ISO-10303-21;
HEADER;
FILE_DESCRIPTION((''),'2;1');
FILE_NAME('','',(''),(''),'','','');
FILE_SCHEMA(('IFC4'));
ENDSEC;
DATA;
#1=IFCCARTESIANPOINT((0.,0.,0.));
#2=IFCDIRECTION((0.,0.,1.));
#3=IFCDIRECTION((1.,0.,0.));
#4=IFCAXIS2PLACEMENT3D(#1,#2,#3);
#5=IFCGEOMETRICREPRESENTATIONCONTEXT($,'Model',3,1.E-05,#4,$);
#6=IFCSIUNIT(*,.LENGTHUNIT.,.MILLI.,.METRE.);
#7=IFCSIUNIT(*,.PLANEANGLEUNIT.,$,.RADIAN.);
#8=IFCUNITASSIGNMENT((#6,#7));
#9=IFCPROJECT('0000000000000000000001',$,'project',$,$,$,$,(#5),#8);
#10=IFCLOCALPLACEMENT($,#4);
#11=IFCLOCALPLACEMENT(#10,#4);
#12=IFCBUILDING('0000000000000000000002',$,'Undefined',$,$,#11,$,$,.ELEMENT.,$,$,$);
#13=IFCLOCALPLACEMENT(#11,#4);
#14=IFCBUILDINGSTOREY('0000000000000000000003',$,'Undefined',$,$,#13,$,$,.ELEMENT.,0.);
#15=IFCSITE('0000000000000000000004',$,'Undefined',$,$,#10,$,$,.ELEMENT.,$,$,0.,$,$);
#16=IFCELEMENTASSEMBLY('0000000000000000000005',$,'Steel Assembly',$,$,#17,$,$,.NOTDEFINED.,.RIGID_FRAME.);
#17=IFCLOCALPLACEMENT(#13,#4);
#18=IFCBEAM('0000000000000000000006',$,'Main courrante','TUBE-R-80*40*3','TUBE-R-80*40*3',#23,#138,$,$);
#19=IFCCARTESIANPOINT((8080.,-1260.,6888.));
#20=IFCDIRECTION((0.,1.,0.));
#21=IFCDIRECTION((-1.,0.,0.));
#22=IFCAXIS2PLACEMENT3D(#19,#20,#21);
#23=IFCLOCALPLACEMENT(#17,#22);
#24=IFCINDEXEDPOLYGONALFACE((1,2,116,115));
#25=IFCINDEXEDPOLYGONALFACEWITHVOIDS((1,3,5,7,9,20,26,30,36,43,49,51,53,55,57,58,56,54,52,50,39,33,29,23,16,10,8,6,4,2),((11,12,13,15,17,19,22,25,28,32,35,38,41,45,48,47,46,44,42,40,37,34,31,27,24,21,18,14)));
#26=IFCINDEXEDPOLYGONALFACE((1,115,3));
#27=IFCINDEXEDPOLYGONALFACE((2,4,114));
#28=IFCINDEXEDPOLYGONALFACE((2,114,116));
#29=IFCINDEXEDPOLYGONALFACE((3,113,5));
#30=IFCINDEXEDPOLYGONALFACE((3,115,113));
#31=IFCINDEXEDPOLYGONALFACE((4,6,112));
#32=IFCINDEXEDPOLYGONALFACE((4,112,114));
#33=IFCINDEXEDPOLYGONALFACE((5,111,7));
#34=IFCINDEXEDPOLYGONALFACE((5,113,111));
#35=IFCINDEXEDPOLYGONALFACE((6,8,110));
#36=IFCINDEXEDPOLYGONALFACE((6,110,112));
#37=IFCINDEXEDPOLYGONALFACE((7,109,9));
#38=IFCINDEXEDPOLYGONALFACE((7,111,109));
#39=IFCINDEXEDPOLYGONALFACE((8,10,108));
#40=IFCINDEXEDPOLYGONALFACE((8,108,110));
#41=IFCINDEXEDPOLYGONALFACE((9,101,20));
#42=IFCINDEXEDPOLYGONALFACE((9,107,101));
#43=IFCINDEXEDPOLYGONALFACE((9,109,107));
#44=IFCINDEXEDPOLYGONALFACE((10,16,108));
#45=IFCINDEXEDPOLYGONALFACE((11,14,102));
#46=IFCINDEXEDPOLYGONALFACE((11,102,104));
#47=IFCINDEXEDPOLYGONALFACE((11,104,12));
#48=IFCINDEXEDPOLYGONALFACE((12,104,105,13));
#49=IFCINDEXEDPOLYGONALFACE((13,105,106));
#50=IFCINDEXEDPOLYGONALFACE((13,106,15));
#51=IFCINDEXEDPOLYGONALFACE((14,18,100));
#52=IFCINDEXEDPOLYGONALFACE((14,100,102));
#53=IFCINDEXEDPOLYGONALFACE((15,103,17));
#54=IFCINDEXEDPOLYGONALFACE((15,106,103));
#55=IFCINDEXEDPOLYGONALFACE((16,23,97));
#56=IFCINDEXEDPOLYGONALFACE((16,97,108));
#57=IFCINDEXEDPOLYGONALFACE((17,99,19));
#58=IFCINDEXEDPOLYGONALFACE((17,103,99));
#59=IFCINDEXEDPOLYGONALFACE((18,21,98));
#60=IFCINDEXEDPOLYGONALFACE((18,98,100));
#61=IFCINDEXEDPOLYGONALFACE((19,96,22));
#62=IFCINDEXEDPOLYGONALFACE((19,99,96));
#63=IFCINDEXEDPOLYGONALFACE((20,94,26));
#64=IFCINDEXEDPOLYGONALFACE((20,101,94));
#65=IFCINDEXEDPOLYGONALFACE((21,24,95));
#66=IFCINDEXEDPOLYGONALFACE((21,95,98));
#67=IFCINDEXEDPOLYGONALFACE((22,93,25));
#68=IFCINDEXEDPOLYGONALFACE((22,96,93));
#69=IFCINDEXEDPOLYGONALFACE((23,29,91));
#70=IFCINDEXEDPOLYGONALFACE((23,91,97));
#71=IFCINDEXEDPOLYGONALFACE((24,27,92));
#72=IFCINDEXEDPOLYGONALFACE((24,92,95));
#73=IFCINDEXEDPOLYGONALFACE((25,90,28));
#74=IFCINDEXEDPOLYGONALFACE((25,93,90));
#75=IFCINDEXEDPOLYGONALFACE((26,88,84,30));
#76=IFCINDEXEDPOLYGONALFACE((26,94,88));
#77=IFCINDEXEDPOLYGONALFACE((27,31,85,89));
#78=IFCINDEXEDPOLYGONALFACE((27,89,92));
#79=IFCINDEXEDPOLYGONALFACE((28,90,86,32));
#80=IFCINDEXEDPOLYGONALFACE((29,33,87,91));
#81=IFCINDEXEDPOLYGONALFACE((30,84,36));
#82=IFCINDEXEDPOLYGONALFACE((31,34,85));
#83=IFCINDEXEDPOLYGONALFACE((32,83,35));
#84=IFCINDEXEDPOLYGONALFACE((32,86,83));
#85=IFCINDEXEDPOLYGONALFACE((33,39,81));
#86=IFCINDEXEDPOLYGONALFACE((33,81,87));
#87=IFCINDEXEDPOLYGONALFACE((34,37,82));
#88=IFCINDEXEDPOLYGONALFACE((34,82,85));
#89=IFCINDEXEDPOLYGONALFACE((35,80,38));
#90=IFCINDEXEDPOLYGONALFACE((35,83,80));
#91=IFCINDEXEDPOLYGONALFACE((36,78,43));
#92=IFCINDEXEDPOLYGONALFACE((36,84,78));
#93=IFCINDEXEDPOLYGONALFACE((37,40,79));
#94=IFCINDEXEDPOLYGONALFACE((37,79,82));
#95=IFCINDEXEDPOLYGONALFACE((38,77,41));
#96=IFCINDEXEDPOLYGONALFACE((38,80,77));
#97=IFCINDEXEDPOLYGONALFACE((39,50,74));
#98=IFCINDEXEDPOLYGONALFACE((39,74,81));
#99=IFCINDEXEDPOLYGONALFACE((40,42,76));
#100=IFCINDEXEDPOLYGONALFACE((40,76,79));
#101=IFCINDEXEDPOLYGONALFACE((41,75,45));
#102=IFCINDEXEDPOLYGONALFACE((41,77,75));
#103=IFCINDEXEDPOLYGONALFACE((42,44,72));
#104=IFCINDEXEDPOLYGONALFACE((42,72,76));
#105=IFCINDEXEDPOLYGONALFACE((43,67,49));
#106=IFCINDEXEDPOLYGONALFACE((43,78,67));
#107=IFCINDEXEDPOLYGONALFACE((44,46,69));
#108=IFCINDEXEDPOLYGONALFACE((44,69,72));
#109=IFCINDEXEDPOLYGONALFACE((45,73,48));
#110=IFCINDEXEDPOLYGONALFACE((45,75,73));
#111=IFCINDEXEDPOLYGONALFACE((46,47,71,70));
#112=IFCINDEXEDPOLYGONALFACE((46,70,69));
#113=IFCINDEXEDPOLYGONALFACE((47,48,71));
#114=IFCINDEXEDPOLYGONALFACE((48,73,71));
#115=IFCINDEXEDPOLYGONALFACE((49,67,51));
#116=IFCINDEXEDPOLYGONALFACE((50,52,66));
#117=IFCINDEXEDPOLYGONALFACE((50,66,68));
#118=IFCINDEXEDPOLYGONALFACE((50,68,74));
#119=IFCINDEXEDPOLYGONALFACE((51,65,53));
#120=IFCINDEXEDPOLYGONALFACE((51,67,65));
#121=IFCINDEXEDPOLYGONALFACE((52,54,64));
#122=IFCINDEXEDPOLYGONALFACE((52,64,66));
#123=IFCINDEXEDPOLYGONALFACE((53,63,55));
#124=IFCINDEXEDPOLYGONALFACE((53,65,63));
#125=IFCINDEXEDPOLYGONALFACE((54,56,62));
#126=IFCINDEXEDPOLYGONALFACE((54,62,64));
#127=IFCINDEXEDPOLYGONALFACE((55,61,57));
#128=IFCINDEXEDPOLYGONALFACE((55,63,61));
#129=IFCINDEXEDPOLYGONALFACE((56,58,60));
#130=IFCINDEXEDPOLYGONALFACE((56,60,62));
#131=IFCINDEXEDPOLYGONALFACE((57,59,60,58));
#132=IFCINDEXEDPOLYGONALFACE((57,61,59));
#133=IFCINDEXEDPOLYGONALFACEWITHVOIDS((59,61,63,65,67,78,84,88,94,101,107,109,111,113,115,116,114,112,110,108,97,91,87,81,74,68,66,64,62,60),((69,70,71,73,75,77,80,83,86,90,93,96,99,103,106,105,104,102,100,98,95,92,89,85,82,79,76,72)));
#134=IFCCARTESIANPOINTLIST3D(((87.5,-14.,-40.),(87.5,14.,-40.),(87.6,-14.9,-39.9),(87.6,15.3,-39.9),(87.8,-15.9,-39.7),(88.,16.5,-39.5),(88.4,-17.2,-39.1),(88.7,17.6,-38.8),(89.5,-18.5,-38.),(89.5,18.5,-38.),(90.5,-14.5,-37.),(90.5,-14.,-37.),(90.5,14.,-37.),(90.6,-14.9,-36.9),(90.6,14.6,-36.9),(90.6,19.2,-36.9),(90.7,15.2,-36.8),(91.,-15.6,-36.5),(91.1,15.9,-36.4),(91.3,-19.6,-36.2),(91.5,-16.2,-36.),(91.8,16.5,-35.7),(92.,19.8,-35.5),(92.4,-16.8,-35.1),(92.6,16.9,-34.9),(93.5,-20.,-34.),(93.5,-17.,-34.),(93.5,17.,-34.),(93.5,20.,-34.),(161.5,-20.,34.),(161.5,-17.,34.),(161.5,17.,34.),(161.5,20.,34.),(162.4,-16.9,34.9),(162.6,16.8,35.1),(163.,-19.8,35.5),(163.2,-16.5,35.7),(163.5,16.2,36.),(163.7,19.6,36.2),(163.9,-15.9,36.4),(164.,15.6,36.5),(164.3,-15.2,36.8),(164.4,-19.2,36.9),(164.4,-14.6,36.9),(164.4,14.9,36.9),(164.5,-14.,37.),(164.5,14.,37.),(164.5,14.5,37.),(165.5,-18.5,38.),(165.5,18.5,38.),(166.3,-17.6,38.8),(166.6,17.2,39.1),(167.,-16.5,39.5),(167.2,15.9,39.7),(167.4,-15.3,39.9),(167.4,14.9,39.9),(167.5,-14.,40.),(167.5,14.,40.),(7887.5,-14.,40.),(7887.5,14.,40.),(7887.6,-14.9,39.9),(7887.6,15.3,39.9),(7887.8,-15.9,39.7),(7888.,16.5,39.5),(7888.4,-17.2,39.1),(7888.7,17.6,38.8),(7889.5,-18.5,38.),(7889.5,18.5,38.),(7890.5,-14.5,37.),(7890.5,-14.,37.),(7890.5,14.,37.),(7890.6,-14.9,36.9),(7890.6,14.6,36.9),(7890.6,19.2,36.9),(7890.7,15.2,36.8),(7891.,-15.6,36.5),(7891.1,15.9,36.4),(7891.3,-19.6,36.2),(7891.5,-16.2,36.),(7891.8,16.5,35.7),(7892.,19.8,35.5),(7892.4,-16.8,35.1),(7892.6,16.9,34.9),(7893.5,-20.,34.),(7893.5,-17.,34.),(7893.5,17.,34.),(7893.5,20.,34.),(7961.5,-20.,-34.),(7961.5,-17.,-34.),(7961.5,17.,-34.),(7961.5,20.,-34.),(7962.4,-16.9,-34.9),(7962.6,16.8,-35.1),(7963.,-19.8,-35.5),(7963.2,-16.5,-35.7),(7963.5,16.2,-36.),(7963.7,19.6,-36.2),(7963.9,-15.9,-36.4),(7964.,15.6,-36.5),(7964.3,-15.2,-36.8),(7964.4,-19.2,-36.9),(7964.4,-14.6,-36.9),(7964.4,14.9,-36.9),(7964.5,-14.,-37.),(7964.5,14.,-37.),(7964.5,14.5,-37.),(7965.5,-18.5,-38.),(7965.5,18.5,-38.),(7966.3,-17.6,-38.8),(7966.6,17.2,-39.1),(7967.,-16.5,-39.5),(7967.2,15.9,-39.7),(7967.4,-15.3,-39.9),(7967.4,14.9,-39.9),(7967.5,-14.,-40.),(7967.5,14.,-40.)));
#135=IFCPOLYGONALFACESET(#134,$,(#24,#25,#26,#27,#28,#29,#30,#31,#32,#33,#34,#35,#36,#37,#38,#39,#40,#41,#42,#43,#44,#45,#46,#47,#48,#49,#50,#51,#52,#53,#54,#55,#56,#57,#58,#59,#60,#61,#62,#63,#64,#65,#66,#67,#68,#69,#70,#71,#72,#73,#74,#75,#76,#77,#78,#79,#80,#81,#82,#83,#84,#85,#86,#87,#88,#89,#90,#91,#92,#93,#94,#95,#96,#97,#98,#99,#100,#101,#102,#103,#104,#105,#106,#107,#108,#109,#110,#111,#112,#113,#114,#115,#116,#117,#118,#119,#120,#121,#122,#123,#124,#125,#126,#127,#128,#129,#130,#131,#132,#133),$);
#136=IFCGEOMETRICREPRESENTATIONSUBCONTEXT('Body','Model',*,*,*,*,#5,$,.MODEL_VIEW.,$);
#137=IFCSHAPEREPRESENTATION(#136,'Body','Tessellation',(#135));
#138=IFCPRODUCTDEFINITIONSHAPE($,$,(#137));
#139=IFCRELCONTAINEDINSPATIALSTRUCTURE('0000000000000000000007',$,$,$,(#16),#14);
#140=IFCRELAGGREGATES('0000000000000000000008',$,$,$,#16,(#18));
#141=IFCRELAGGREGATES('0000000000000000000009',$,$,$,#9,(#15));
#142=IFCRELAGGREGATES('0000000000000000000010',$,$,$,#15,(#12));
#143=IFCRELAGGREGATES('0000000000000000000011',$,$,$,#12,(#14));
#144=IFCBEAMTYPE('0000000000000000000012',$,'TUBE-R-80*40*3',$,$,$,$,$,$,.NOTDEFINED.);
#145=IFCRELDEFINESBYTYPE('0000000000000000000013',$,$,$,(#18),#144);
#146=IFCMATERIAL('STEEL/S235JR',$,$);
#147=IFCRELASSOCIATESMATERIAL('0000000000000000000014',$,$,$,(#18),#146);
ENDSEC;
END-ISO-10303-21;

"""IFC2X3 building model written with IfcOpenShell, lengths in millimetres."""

from ifc_helpers import new_model, si_unit, frame, origin_with_axes, origin_2d_with_axis, place, context, subcontext, project, spatial, hollow_rectangle, extrude, clip, halfspace, material, type_object, element, aggregate, save


model = new_model("IFC2X3")

# Units and contexts
model_context = context("Model", 3, precision=1e-05, world=origin_with_axes())
body_context = subcontext(model_context, "Body", "Model", "MODEL_VIEW")
ifc_project = project(units=[si_unit("LENGTHUNIT", "METRE", prefix="MILLI"), si_unit("PLANEANGLEUNIT", "RADIAN")], contexts=[model_context])

# Site, building, storey
site_placement = place(None, origin_with_axes())
site = spatial("IfcSite", under=ifc_project, at=site_placement, Name="Undefined", CompositionType="ELEMENT", RefElevation=0.0)
building_placement = place(site_placement, origin_with_axes())
building = spatial("IfcBuilding", under=site, at=building_placement, Name="Undefined", CompositionType="ELEMENT")
storey_placement = place(building_placement, origin_with_axes())
storey = spatial("IfcBuildingStorey", under=building, at=storey_placement, Name="Undefined", CompositionType="ELEMENT", Elevation=0.0)

# Element assembly, beam
assembly_1_placement = place(storey_placement, origin_with_axes())
assembly_1 = element("IfcElementAssembly", 1, at=assembly_1_placement, inside=storey, Name="Steel Assembly", AssemblyPlace="NOTDEFINED", PredefinedType="RIGID_FRAME")
ifc_material_1 = material(Name="STEEL/S235JR")
beam_type_1 = type_object("IfcBeamType", Name="TUBE-R-80*40*3", PredefinedType="NOTDEFINED")
beam_1_placement = place(assembly_1_placement, frame((8080.0, -1260.0, 6888.0), z_axis=(0.0, 1.0, 0.0), x_axis=(-1.0, 0.0, 0.0)))
beam_1 = element("IfcBeam", 2, at=beam_1_placement, type_object=beam_type_1, material=ifc_material_1, Name="Main courrante", Description="TUBE-R-80*40*3", ObjectType="TUBE-R-80*40*3", context=body_context, shape_type="Clipping", body=[
    clip(clip(extrude(hollow_rectangle(XDim=40.0, YDim=80.0, WallThickness=3.0, InnerFilletRadius=3.0, OuterFilletRadius=6.0, at=origin_2d_with_axis()), frame((8008.3, 0.0, 0.0), z_axis=(-1.0, 0.0, 0.0), x_axis=(0.0, -1.0, 0.0)), (0.0, 0.0, 1.0), 7961.6), halfspace(frame((7951.1, 0.0, -23.6), z_axis=(-0.707107, 0.0, -0.707107), x_axis=(0.0, 1.0, 0.0)), True)), halfspace(frame((103.9, 0.0, -23.6), z_axis=(0.707107, 0.0, -0.707107), x_axis=(0.707107, 0.0, 0.707107)), True)),
])

aggregate(assembly_1, [beam_1])

save(model, "model.ifc")
